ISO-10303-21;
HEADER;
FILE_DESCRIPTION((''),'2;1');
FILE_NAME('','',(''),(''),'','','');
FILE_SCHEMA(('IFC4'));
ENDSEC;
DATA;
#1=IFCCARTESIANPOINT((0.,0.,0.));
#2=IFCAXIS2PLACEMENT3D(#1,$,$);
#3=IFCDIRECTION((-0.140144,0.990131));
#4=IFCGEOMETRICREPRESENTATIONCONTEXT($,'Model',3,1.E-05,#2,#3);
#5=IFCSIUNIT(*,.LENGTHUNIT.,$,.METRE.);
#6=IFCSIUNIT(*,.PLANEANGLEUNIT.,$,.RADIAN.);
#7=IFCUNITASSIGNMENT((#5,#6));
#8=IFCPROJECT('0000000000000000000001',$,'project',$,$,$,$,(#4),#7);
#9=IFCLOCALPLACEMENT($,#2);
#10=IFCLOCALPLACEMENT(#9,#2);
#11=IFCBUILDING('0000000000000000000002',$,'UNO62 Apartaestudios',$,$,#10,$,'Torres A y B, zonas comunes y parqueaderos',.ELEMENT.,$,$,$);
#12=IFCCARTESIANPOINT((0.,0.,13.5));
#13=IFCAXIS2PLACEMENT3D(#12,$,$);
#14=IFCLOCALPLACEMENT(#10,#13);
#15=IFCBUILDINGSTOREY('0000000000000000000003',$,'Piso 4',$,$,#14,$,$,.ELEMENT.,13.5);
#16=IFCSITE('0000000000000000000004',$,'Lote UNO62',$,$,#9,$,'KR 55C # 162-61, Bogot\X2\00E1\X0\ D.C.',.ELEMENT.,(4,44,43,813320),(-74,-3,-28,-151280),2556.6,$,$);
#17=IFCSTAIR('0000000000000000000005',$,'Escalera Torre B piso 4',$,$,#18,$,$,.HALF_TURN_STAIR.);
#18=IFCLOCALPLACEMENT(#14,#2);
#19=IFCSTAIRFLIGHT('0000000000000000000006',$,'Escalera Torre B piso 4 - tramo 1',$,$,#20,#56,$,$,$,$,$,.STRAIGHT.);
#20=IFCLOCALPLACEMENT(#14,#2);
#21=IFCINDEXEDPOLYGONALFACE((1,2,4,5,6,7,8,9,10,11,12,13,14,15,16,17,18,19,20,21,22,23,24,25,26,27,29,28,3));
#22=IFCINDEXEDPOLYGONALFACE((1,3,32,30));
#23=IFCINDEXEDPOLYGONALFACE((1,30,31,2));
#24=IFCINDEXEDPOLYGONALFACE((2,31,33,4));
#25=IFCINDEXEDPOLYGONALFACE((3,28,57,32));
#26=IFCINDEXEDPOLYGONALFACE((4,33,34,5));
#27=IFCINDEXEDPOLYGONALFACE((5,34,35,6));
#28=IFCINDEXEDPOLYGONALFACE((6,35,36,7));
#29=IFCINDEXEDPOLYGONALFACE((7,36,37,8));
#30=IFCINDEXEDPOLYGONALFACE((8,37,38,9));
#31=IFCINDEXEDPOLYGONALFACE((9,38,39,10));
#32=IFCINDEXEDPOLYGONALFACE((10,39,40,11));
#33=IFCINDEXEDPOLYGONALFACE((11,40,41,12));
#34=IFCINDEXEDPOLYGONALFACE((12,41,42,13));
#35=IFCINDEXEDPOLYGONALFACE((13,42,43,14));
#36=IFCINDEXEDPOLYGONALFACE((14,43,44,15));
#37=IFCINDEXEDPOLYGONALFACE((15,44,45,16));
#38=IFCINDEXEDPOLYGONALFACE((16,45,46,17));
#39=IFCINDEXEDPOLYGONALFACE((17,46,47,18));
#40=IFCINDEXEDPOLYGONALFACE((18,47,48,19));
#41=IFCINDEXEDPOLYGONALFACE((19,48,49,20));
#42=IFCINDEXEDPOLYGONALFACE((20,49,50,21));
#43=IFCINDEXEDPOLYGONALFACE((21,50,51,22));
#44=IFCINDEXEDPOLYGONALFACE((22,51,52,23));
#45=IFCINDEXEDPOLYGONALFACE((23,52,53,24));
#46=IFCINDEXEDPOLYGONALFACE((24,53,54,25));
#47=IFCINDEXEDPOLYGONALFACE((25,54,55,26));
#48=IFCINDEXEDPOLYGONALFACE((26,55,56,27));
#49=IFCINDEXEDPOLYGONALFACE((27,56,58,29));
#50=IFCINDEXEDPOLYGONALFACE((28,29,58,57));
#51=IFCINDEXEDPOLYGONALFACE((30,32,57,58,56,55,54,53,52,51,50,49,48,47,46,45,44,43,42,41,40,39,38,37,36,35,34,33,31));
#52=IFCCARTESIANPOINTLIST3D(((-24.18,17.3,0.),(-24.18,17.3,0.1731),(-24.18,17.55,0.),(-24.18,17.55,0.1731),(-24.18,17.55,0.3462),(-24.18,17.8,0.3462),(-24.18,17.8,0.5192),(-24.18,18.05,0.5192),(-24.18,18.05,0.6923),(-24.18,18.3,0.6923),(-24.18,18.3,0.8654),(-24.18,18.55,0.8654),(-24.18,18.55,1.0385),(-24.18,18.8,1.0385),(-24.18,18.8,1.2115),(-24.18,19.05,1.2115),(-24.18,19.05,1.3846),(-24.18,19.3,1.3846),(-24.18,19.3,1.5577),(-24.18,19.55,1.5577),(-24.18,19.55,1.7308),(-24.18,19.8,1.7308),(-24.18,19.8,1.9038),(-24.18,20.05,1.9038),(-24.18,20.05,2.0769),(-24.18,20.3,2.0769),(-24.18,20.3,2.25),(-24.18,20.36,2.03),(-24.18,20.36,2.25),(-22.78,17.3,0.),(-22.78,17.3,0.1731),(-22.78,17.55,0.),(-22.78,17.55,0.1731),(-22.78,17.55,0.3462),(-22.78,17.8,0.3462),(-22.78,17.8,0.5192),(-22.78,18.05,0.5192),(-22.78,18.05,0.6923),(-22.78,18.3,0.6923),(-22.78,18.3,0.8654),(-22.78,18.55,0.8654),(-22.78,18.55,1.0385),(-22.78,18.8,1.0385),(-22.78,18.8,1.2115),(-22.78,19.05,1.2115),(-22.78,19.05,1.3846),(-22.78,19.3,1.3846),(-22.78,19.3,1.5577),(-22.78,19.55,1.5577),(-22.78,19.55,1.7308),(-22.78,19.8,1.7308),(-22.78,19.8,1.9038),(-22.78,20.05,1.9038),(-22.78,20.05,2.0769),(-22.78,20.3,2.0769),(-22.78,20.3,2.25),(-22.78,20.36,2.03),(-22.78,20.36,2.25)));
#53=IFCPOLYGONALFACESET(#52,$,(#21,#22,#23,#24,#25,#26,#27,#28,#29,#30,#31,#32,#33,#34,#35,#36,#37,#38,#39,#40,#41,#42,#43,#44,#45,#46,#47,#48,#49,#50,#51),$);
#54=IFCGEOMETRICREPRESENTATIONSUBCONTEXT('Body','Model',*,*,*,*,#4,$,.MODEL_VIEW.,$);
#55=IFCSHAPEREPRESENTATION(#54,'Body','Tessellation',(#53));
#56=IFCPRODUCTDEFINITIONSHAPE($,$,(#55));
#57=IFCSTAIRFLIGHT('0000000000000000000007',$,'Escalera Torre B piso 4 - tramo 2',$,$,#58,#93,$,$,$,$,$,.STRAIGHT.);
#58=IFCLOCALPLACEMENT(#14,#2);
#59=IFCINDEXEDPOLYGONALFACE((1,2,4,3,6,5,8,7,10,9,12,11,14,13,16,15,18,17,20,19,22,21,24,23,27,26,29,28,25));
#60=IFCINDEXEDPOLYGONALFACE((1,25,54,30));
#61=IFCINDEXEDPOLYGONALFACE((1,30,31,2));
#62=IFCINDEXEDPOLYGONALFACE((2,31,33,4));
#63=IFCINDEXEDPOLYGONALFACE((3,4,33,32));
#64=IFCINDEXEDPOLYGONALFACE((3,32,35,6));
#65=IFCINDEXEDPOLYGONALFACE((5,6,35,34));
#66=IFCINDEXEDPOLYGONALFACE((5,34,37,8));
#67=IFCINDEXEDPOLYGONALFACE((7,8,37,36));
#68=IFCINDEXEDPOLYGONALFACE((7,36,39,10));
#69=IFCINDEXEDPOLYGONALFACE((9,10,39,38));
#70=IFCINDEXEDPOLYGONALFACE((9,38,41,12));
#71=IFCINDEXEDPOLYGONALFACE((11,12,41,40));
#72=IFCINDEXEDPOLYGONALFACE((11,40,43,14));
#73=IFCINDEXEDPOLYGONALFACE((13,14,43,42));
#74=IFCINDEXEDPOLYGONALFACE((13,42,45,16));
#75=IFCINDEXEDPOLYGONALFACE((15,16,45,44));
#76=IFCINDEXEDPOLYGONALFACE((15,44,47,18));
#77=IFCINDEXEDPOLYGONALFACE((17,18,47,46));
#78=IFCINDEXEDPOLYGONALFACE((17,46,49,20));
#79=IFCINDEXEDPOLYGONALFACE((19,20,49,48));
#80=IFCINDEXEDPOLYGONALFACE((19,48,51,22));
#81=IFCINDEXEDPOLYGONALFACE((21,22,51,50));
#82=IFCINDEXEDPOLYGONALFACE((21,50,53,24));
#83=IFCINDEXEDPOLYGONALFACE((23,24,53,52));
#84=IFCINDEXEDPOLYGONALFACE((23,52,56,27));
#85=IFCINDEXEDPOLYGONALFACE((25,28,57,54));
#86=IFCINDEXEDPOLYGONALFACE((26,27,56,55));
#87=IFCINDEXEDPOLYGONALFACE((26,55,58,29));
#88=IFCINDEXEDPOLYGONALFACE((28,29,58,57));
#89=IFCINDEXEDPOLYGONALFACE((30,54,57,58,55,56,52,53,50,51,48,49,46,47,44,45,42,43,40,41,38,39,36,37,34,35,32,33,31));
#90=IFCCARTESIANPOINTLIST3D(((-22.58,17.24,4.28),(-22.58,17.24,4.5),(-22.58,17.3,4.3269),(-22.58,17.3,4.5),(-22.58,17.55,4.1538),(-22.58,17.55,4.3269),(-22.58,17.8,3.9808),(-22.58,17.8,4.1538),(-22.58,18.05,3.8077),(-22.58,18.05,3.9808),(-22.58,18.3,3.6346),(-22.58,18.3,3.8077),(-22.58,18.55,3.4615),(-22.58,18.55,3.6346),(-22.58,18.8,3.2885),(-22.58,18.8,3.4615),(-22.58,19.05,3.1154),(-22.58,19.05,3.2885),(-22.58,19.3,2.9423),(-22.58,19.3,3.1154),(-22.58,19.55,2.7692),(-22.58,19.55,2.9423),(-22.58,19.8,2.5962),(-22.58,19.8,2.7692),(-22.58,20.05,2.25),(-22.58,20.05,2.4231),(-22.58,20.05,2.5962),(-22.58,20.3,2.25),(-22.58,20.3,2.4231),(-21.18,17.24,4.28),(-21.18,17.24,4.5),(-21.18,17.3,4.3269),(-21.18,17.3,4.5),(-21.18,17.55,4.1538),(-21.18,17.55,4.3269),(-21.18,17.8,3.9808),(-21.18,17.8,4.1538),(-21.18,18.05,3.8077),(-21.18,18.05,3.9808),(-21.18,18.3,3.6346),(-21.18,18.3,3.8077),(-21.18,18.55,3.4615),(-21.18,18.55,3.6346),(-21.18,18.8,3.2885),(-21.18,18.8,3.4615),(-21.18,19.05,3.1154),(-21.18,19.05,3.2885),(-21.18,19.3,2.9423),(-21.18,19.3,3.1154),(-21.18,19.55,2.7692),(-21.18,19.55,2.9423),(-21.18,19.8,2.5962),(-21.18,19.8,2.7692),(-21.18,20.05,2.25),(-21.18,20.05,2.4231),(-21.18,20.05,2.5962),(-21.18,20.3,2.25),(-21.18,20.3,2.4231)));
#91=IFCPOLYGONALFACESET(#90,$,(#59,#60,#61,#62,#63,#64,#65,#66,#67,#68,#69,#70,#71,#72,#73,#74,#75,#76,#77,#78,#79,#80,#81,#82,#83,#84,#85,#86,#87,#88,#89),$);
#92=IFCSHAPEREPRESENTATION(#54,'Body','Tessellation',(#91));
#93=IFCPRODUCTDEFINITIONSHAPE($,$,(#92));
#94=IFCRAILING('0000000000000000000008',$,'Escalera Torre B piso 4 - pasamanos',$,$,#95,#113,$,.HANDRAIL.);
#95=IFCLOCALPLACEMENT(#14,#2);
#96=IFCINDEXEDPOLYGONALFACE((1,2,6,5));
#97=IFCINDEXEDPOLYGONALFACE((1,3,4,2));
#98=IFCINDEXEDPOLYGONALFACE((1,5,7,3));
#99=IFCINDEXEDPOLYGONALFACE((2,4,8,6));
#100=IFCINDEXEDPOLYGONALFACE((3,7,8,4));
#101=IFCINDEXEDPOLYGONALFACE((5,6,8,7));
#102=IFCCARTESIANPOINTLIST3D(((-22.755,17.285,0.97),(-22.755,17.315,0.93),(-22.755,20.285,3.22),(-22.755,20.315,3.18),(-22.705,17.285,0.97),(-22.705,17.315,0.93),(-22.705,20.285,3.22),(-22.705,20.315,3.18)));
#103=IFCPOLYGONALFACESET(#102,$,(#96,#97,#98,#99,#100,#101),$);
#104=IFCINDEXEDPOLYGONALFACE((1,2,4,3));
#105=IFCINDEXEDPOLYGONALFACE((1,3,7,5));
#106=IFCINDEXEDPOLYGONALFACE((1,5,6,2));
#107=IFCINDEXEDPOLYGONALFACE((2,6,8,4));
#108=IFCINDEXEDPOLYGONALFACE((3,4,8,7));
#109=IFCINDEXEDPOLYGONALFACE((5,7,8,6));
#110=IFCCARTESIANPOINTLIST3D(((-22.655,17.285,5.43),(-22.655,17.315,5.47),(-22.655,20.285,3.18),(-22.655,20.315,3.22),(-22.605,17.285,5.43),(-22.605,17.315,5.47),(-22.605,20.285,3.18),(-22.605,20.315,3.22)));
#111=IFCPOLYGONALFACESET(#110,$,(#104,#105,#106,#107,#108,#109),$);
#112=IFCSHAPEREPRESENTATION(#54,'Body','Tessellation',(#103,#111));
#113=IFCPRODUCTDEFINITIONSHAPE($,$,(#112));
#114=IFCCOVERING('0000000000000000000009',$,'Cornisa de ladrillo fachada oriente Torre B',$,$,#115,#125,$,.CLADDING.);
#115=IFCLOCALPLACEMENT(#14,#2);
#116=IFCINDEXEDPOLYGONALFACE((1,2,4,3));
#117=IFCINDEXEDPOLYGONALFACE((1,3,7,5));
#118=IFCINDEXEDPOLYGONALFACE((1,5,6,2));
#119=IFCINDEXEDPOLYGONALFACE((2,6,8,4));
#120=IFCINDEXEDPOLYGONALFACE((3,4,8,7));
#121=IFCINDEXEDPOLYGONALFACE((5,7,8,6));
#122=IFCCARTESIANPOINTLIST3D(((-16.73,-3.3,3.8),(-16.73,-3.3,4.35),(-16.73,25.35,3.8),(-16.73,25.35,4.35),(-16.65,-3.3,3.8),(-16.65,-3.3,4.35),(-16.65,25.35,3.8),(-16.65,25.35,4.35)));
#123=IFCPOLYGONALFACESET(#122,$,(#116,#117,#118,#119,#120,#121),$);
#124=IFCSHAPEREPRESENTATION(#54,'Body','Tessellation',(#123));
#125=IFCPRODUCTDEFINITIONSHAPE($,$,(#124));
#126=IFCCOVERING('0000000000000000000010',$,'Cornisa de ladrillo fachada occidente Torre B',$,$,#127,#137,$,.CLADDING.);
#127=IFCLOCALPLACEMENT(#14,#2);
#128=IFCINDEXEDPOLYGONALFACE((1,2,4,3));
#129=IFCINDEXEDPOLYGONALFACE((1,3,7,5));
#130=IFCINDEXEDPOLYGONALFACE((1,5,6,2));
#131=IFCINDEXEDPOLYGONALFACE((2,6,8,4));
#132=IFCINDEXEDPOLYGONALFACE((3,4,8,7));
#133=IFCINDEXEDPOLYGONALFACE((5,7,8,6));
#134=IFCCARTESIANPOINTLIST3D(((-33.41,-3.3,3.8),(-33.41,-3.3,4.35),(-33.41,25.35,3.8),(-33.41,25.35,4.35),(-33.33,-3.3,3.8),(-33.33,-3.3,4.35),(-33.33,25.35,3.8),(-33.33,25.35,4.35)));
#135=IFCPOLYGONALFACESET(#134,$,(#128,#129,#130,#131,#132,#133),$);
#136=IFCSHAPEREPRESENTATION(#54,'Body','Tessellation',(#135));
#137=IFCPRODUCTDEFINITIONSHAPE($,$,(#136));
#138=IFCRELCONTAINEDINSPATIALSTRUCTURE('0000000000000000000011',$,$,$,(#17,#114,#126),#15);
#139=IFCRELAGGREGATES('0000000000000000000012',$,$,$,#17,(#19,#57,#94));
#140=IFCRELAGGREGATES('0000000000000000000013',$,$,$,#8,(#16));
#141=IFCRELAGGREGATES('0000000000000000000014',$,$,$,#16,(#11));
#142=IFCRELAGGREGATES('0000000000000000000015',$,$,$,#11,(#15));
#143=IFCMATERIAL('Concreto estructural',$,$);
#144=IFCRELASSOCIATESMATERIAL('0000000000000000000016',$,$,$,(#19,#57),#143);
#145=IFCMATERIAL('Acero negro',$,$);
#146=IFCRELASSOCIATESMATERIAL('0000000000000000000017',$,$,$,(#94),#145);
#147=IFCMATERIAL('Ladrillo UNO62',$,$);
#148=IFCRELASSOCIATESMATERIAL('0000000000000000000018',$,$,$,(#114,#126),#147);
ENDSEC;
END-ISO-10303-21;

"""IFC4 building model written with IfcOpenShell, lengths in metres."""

from ifc_helpers import new_model, si_unit, direction, frame, frame_2d, origin, origin_2d, place, context, subcontext, project, spatial, polyline, rectangle, outline, extrude, material, element, aggregate, save


model = new_model("IFC4")

# Units and contexts
model_context = context("Model", 3, precision=1e-05, world=origin(), true_north=direction((-0.140144, 0.990131)))
body_context = subcontext(model_context, "Body", "Model", "MODEL_VIEW")
ifc_project = project(units=[si_unit("LENGTHUNIT", "METRE"), si_unit("PLANEANGLEUNIT", "RADIAN")], contexts=[model_context])

# Site, building, storey
site_placement = place(None, origin())
site = spatial("IfcSite", under=ifc_project, at=site_placement, Name="Lote UNO62", LongName="KR 55C # 162-61, Bogotá D.C.", CompositionType="ELEMENT", RefLatitude=(4, 44, 43, 813320), RefLongitude=(-74, -3, -28, -151280), RefElevation=2556.6)
building_placement = place(site_placement, origin())
building = spatial("IfcBuilding", under=site, at=building_placement, Name="UNO62 Apartaestudios", LongName="Torres A y B, zonas comunes y parqueaderos", CompositionType="ELEMENT")
storey_placement = place(building_placement, frame((0.0, 0.0, 13.5)))
storey = spatial("IfcBuildingStorey", under=building, at=storey_placement, Name="Piso 4", CompositionType="ELEMENT", Elevation=13.5)

# Shared definitions
ifc_material_1 = material(Name="Ladrillo UNO62")

# Stair
stair_placement = place(storey_placement, origin())
stair = element("IfcStair", 1, at=stair_placement, inside=storey, Name="Escalera Torre B piso 4", PredefinedType="HALF_TURN_STAIR")
ifc_material_2 = material(Name="Concreto estructural")

# Stair flights
stair_flight_1_placement = place(storey_placement, origin())
stair_flight_1 = element("IfcStairFlight", 2, at=stair_flight_1_placement, material=ifc_material_2, Name="Escalera Torre B piso 4 - tramo 1", PredefinedType="STRAIGHT", context=body_context, shape_type="SweptSolid", body=[
    extrude(outline(polyline([(0.0, 0.0), (0.0, 0.1731), (0.25, 0.1731), (0.25, 0.3462), (0.5, 0.3462), (0.5, 0.5192), (0.75, 0.5192), (0.75, 0.6923), (1.0, 0.6923), (1.0, 0.8654), (1.25, 0.8654), (1.25, 1.0385), (1.5, 1.0385), (1.5, 1.2115), (1.75, 1.2115), (1.75, 1.3846), (2.0, 1.3846), (2.0, 1.5577), (2.25, 1.5577), (2.25, 1.7308), (2.5, 1.7308), (2.5, 1.9038), (2.75, 1.9038), (2.75, 2.0769), (3.0, 2.0769), (3.0, 2.25), (3.06, 2.25), (3.06, 2.03), (0.25, 0.0), (0.0, 0.0)])), frame((-24.18, 17.3, 0.0), z_axis=(1.0, 0.0, 0.0), x_axis=(0.0, 1.0, 0.0)), (0.0, 0.0, 1.0), 1.4),
])
stair_flight_2_placement = place(storey_placement, origin())
stair_flight_2 = element("IfcStairFlight", 3, at=stair_flight_2_placement, material=ifc_material_2, Name="Escalera Torre B piso 4 - tramo 2", PredefinedType="STRAIGHT", context=body_context, shape_type="SweptSolid", body=[
    extrude(outline(polyline([(0.0, 0.0), (0.0, 0.1731), (0.25, 0.1731), (0.25, 0.3462), (0.5, 0.3462), (0.5, 0.5192), (0.75, 0.5192), (0.75, 0.6923), (1.0, 0.6923), (1.0, 0.8654), (1.25, 0.8654), (1.25, 1.0385), (1.5, 1.0385), (1.5, 1.2115), (1.75, 1.2115), (1.75, 1.3846), (2.0, 1.3846), (2.0, 1.5577), (2.25, 1.5577), (2.25, 1.7308), (2.5, 1.7308), (2.5, 1.9038), (2.75, 1.9038), (2.75, 2.0769), (3.0, 2.0769), (3.0, 2.25), (3.06, 2.25), (3.06, 2.03), (0.25, 0.0), (0.0, 0.0)])), frame((-21.18, 20.3, 2.25), z_axis=(-1.0, 0.0, 0.0), x_axis=(0.0, -1.0, 0.0)), (0.0, 0.0, 1.0), 1.4),
])

# Railing
ifc_material_3 = material(Name="Acero negro")
railing_1_placement = place(storey_placement, origin())
railing_1 = element("IfcRailing", 4, at=railing_1_placement, material=ifc_material_3, Name="Escalera Torre B piso 4 - pasamanos", PredefinedType="HANDRAIL", context=body_context, shape_type="SweptSolid", body=[
    extrude(rectangle(XDim=0.05, YDim=0.05, at=origin_2d()), frame((-22.73, 17.3, 0.95), z_axis=(0.0, 0.8, 0.6), x_axis=(1.0, 0.0, 0.0)), (0.0, 0.0, 1.0), 3.75),
    extrude(rectangle(XDim=0.05, YDim=0.05, at=origin_2d()), frame((-22.63, 20.3, 3.2), z_axis=(0.0, -0.8, 0.6), x_axis=(-1.0, 0.0, 0.0)), (0.0, 0.0, 1.0), 3.75),
])
aggregate(stair, [stair_flight_1, stair_flight_2, railing_1])

# Coverings
covering_1_placement = place(storey_placement, origin())
element("IfcCovering", 5, at=covering_1_placement, inside=storey, material=ifc_material_1, Name="Cornisa de ladrillo fachada oriente Torre B", PredefinedType="CLADDING", context=body_context, shape_type="SweptSolid", body=[
    extrude(rectangle(XDim=0.08, YDim=28.65, at=frame_2d((-16.69, 11.025))), frame((0.0, 0.0, 3.8)), (0.0, 0.0, 1.0), 0.55),
])
covering_2_placement = place(storey_placement, origin())
element("IfcCovering", 6, at=covering_2_placement, inside=storey, material=ifc_material_1, Name="Cornisa de ladrillo fachada occidente Torre B", PredefinedType="CLADDING", context=body_context, shape_type="SweptSolid", body=[
    extrude(rectangle(XDim=0.08, YDim=28.65, at=frame_2d((-33.37, 11.025))), frame((0.0, 0.0, 3.8)), (0.0, 0.0, 1.0), 0.55),
])

save(model, "model.ifc")
